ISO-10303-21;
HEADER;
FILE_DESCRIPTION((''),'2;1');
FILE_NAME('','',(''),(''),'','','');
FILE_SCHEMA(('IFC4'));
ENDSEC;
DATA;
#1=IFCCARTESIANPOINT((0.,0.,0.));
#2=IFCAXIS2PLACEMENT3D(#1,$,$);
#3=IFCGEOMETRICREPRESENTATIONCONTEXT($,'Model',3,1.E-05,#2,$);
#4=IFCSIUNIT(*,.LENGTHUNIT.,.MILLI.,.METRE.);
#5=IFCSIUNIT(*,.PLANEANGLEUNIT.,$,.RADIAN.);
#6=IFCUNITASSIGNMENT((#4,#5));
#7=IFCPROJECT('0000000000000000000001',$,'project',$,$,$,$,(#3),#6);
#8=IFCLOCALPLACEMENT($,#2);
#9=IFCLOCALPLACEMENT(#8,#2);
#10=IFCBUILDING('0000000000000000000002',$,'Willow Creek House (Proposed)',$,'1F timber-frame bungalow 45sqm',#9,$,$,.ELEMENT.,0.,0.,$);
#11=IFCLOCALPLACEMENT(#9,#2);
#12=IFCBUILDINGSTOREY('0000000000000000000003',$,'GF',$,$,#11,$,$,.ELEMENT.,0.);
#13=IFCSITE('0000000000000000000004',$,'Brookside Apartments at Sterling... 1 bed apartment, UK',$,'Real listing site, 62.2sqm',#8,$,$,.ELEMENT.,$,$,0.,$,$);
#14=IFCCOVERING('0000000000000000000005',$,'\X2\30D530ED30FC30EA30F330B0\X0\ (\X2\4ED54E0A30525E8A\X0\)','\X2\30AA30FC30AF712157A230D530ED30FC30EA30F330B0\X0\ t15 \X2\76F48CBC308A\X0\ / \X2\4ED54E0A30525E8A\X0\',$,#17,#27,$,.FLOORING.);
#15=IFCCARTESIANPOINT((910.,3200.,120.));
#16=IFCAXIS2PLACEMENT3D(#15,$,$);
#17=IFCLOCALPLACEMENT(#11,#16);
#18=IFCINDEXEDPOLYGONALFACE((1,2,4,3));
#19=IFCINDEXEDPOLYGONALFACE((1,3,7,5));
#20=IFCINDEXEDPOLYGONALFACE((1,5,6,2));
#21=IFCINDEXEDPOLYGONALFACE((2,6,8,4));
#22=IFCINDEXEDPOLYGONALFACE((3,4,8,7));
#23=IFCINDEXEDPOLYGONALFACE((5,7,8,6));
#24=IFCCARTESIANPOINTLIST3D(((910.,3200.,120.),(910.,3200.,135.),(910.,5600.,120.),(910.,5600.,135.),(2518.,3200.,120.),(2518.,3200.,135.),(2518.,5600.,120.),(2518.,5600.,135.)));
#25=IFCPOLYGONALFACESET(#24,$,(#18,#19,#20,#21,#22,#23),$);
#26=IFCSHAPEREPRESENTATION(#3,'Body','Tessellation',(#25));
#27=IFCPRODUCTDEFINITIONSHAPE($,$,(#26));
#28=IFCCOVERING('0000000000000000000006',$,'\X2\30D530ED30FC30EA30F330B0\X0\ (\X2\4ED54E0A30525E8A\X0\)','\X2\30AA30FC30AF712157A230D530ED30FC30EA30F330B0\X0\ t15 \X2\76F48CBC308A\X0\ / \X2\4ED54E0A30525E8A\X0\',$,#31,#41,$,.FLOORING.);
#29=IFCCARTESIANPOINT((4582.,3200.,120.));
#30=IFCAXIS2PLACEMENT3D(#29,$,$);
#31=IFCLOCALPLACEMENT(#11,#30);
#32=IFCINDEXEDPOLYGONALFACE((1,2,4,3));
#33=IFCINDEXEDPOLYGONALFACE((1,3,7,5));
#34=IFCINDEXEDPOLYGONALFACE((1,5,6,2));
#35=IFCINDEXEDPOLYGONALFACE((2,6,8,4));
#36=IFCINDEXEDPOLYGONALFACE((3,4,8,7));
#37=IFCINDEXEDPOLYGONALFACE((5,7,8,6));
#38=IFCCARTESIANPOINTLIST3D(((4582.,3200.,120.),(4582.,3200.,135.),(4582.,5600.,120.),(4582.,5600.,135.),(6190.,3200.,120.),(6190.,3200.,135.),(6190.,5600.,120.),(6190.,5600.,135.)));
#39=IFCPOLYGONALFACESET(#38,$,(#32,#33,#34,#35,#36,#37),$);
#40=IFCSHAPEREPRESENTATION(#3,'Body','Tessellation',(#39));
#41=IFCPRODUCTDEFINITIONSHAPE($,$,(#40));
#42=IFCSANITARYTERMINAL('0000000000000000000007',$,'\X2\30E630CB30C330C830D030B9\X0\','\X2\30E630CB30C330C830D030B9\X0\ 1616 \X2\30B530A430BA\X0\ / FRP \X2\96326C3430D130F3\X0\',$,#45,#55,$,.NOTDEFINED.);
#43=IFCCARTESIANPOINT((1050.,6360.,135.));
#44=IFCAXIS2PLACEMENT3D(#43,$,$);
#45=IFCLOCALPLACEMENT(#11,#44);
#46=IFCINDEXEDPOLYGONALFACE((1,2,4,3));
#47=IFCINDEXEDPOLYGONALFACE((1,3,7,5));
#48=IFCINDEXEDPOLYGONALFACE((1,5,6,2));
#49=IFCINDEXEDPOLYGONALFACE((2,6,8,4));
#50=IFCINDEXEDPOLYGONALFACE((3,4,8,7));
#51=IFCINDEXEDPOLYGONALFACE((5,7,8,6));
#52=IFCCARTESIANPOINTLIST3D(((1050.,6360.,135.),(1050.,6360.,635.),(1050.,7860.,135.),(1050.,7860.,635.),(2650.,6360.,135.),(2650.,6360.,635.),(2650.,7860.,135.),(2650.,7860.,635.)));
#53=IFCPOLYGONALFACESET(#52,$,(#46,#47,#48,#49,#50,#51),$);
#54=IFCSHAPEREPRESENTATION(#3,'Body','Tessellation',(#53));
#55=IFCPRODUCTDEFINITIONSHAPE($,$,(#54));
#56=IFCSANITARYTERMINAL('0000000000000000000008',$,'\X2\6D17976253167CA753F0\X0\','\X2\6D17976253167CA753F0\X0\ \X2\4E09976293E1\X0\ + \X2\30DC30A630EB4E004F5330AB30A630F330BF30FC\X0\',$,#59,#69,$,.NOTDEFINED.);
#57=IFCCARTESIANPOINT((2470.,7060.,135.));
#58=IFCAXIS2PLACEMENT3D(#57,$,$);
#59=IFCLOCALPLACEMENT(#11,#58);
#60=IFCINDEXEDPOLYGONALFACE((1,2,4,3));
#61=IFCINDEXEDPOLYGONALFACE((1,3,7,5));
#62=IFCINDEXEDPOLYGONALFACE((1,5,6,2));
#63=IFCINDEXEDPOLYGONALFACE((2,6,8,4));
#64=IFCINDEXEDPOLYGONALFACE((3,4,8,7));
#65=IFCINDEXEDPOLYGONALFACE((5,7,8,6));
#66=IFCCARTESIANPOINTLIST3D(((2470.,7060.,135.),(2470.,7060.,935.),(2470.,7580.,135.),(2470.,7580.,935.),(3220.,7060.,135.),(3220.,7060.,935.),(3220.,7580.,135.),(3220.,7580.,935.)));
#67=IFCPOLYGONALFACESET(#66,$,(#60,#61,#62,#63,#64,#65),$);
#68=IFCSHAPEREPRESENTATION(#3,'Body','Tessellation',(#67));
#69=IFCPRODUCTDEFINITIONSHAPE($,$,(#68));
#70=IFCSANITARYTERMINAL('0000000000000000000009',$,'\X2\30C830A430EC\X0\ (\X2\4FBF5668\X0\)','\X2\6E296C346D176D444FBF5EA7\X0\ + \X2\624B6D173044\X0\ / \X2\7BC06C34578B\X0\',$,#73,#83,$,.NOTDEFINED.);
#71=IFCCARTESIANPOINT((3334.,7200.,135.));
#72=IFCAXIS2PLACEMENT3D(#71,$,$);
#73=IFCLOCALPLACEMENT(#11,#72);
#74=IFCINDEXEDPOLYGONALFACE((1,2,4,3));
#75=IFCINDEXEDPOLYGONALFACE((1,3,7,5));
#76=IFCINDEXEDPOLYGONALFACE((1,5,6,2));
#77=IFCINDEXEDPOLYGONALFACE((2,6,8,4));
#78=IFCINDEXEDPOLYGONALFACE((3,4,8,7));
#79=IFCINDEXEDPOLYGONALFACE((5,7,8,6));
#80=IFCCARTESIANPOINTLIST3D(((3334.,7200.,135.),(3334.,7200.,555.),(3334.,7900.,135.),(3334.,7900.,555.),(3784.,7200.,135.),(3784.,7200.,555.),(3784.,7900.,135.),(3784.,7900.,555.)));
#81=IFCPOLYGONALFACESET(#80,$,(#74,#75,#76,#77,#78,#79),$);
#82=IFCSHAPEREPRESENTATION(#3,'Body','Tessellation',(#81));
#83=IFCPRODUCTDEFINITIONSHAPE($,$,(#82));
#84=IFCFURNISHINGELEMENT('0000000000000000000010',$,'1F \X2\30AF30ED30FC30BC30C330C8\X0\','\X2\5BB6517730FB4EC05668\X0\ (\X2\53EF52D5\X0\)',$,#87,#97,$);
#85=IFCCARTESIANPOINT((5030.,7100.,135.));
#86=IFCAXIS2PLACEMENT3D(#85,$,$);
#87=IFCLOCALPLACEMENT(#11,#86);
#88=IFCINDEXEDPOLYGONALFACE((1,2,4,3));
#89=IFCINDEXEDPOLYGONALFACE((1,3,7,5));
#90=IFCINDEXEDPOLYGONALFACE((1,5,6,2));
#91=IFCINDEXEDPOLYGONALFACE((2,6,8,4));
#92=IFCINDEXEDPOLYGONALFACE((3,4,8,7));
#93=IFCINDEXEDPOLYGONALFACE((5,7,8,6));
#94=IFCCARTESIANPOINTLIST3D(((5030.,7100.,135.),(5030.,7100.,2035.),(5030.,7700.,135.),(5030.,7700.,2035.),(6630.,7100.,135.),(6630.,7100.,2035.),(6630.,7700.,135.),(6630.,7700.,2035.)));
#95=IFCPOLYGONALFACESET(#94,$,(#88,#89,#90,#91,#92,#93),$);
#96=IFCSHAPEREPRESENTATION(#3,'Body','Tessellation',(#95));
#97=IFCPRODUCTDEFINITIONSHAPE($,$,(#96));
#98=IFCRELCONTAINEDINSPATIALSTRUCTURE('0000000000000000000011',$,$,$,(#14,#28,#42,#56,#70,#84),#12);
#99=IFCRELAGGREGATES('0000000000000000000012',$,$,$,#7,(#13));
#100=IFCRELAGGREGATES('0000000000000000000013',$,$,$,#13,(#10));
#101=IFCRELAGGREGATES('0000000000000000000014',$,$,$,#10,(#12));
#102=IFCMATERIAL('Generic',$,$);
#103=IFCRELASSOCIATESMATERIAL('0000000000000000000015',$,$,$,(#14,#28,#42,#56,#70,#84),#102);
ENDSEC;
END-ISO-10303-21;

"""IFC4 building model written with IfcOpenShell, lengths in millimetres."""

from ifc_helpers import new_model, si_unit, frame, frame_2d, origin, place, context, project, spatial, rectangle, extrude, material, element, save


model = new_model("IFC4")

# Units and contexts
model_context = context("Model", 3, precision=1e-05, world=origin())
ifc_project = project(units=[si_unit("LENGTHUNIT", "METRE", prefix="MILLI"), si_unit("PLANEANGLEUNIT", "RADIAN")], contexts=[model_context])

# Site, building, storey
site_placement = place(None, origin())
site = spatial("IfcSite", under=ifc_project, at=site_placement, Name="Brookside Apartments at Sterling... 1 bed apartment, UK", ObjectType="Real listing site, 62.2sqm", CompositionType="ELEMENT", RefElevation=0.0)
building_placement = place(site_placement, origin())
building = spatial("IfcBuilding", under=site, at=building_placement, Name="Willow Creek House (Proposed)", ObjectType="1F timber-frame bungalow 45sqm", CompositionType="ELEMENT", ElevationOfRefHeight=0.0, ElevationOfTerrain=0.0)
storey_placement = place(building_placement, origin())
storey = spatial("IfcBuildingStorey", under=building, at=storey_placement, Name="GF", CompositionType="ELEMENT", Elevation=0.0)

# Coverings
ifc_material_1 = material(Name="Generic")
covering_1_placement = place(storey_placement, frame((910.0, 3200.0, 120.0)))
element("IfcCovering", 1, at=covering_1_placement, inside=storey, material=ifc_material_1, Name="フローリング (仕上げ床)", Description="オーク無垢フローリング t15 直貼り / 仕上げ床", PredefinedType="FLOORING", context=model_context, shape_type="SweptSolid", body=[
    extrude(rectangle(XDim=1608.0, YDim=2400.0, at=frame_2d((804.0, 1200.0))), frame((910.0, 3200.0, 120.0)), (0.0, 0.0, 1.0), 15.0),
])
covering_2_placement = place(storey_placement, frame((4582.0, 3200.0, 120.0)))
element("IfcCovering", 2, at=covering_2_placement, inside=storey, material=ifc_material_1, Name="フローリング (仕上げ床)", Description="オーク無垢フローリング t15 直貼り / 仕上げ床", PredefinedType="FLOORING", context=model_context, shape_type="SweptSolid", body=[
    extrude(rectangle(XDim=1608.0, YDim=2400.0, at=frame_2d((804.0, 1200.0))), frame((4582.0, 3200.0, 120.0)), (0.0, 0.0, 1.0), 15.0),
])

# Sanitary terminals
sanitary_terminal_1_placement = place(storey_placement, frame((1050.0, 6360.0, 135.0)))
element("IfcSanitaryTerminal", 3, at=sanitary_terminal_1_placement, inside=storey, material=ifc_material_1, Name="ユニットバス", Description="ユニットバス 1616 サイズ / FRP 防水パン", PredefinedType="NOTDEFINED", context=model_context, shape_type="SweptSolid", body=[
    extrude(rectangle(XDim=1600.0, YDim=1500.0, at=frame_2d((800.0, 750.0))), frame((1050.0, 6360.0, 135.0)), (0.0, 0.0, 1.0), 500.0),
])
sanitary_terminal_2_placement = place(storey_placement, frame((2470.0, 7060.0, 135.0)))
element("IfcSanitaryTerminal", 4, at=sanitary_terminal_2_placement, inside=storey, material=ifc_material_1, Name="洗面化粧台", Description="洗面化粧台 三面鏡 + ボウル一体カウンター", PredefinedType="NOTDEFINED", context=model_context, shape_type="SweptSolid", body=[
    extrude(rectangle(XDim=750.0, YDim=520.0, at=frame_2d((375.0, 260.0))), frame((2470.0, 7060.0, 135.0)), (0.0, 0.0, 1.0), 800.0),
])
sanitary_terminal_3_placement = place(storey_placement, frame((3334.0, 7200.0, 135.0)))
element("IfcSanitaryTerminal", 5, at=sanitary_terminal_3_placement, inside=storey, material=ifc_material_1, Name="トイレ (便器)", Description="温水洗浄便座 + 手洗い / 節水型", PredefinedType="NOTDEFINED", context=model_context, shape_type="SweptSolid", body=[
    extrude(rectangle(XDim=450.0, YDim=700.0, at=frame_2d((225.0, 350.0))), frame((3334.0, 7200.0, 135.0)), (0.0, 0.0, 1.0), 420.0),
])

# Furnishing element
furnishing_placement = place(storey_placement, frame((5030.0, 7100.0, 135.0)))
element("IfcFurnishingElement", 6, at=furnishing_placement, inside=storey, material=ifc_material_1, Name="1F クローゼット", Description="家具・什器 (可動)", context=model_context, shape_type="SweptSolid", body=[
    extrude(rectangle(XDim=1600.0, YDim=600.0, at=frame_2d((800.0, 300.0))), frame((5030.0, 7100.0, 135.0)), (0.0, 0.0, 1.0), 1900.0),
])

save(model, "model.ifc")
